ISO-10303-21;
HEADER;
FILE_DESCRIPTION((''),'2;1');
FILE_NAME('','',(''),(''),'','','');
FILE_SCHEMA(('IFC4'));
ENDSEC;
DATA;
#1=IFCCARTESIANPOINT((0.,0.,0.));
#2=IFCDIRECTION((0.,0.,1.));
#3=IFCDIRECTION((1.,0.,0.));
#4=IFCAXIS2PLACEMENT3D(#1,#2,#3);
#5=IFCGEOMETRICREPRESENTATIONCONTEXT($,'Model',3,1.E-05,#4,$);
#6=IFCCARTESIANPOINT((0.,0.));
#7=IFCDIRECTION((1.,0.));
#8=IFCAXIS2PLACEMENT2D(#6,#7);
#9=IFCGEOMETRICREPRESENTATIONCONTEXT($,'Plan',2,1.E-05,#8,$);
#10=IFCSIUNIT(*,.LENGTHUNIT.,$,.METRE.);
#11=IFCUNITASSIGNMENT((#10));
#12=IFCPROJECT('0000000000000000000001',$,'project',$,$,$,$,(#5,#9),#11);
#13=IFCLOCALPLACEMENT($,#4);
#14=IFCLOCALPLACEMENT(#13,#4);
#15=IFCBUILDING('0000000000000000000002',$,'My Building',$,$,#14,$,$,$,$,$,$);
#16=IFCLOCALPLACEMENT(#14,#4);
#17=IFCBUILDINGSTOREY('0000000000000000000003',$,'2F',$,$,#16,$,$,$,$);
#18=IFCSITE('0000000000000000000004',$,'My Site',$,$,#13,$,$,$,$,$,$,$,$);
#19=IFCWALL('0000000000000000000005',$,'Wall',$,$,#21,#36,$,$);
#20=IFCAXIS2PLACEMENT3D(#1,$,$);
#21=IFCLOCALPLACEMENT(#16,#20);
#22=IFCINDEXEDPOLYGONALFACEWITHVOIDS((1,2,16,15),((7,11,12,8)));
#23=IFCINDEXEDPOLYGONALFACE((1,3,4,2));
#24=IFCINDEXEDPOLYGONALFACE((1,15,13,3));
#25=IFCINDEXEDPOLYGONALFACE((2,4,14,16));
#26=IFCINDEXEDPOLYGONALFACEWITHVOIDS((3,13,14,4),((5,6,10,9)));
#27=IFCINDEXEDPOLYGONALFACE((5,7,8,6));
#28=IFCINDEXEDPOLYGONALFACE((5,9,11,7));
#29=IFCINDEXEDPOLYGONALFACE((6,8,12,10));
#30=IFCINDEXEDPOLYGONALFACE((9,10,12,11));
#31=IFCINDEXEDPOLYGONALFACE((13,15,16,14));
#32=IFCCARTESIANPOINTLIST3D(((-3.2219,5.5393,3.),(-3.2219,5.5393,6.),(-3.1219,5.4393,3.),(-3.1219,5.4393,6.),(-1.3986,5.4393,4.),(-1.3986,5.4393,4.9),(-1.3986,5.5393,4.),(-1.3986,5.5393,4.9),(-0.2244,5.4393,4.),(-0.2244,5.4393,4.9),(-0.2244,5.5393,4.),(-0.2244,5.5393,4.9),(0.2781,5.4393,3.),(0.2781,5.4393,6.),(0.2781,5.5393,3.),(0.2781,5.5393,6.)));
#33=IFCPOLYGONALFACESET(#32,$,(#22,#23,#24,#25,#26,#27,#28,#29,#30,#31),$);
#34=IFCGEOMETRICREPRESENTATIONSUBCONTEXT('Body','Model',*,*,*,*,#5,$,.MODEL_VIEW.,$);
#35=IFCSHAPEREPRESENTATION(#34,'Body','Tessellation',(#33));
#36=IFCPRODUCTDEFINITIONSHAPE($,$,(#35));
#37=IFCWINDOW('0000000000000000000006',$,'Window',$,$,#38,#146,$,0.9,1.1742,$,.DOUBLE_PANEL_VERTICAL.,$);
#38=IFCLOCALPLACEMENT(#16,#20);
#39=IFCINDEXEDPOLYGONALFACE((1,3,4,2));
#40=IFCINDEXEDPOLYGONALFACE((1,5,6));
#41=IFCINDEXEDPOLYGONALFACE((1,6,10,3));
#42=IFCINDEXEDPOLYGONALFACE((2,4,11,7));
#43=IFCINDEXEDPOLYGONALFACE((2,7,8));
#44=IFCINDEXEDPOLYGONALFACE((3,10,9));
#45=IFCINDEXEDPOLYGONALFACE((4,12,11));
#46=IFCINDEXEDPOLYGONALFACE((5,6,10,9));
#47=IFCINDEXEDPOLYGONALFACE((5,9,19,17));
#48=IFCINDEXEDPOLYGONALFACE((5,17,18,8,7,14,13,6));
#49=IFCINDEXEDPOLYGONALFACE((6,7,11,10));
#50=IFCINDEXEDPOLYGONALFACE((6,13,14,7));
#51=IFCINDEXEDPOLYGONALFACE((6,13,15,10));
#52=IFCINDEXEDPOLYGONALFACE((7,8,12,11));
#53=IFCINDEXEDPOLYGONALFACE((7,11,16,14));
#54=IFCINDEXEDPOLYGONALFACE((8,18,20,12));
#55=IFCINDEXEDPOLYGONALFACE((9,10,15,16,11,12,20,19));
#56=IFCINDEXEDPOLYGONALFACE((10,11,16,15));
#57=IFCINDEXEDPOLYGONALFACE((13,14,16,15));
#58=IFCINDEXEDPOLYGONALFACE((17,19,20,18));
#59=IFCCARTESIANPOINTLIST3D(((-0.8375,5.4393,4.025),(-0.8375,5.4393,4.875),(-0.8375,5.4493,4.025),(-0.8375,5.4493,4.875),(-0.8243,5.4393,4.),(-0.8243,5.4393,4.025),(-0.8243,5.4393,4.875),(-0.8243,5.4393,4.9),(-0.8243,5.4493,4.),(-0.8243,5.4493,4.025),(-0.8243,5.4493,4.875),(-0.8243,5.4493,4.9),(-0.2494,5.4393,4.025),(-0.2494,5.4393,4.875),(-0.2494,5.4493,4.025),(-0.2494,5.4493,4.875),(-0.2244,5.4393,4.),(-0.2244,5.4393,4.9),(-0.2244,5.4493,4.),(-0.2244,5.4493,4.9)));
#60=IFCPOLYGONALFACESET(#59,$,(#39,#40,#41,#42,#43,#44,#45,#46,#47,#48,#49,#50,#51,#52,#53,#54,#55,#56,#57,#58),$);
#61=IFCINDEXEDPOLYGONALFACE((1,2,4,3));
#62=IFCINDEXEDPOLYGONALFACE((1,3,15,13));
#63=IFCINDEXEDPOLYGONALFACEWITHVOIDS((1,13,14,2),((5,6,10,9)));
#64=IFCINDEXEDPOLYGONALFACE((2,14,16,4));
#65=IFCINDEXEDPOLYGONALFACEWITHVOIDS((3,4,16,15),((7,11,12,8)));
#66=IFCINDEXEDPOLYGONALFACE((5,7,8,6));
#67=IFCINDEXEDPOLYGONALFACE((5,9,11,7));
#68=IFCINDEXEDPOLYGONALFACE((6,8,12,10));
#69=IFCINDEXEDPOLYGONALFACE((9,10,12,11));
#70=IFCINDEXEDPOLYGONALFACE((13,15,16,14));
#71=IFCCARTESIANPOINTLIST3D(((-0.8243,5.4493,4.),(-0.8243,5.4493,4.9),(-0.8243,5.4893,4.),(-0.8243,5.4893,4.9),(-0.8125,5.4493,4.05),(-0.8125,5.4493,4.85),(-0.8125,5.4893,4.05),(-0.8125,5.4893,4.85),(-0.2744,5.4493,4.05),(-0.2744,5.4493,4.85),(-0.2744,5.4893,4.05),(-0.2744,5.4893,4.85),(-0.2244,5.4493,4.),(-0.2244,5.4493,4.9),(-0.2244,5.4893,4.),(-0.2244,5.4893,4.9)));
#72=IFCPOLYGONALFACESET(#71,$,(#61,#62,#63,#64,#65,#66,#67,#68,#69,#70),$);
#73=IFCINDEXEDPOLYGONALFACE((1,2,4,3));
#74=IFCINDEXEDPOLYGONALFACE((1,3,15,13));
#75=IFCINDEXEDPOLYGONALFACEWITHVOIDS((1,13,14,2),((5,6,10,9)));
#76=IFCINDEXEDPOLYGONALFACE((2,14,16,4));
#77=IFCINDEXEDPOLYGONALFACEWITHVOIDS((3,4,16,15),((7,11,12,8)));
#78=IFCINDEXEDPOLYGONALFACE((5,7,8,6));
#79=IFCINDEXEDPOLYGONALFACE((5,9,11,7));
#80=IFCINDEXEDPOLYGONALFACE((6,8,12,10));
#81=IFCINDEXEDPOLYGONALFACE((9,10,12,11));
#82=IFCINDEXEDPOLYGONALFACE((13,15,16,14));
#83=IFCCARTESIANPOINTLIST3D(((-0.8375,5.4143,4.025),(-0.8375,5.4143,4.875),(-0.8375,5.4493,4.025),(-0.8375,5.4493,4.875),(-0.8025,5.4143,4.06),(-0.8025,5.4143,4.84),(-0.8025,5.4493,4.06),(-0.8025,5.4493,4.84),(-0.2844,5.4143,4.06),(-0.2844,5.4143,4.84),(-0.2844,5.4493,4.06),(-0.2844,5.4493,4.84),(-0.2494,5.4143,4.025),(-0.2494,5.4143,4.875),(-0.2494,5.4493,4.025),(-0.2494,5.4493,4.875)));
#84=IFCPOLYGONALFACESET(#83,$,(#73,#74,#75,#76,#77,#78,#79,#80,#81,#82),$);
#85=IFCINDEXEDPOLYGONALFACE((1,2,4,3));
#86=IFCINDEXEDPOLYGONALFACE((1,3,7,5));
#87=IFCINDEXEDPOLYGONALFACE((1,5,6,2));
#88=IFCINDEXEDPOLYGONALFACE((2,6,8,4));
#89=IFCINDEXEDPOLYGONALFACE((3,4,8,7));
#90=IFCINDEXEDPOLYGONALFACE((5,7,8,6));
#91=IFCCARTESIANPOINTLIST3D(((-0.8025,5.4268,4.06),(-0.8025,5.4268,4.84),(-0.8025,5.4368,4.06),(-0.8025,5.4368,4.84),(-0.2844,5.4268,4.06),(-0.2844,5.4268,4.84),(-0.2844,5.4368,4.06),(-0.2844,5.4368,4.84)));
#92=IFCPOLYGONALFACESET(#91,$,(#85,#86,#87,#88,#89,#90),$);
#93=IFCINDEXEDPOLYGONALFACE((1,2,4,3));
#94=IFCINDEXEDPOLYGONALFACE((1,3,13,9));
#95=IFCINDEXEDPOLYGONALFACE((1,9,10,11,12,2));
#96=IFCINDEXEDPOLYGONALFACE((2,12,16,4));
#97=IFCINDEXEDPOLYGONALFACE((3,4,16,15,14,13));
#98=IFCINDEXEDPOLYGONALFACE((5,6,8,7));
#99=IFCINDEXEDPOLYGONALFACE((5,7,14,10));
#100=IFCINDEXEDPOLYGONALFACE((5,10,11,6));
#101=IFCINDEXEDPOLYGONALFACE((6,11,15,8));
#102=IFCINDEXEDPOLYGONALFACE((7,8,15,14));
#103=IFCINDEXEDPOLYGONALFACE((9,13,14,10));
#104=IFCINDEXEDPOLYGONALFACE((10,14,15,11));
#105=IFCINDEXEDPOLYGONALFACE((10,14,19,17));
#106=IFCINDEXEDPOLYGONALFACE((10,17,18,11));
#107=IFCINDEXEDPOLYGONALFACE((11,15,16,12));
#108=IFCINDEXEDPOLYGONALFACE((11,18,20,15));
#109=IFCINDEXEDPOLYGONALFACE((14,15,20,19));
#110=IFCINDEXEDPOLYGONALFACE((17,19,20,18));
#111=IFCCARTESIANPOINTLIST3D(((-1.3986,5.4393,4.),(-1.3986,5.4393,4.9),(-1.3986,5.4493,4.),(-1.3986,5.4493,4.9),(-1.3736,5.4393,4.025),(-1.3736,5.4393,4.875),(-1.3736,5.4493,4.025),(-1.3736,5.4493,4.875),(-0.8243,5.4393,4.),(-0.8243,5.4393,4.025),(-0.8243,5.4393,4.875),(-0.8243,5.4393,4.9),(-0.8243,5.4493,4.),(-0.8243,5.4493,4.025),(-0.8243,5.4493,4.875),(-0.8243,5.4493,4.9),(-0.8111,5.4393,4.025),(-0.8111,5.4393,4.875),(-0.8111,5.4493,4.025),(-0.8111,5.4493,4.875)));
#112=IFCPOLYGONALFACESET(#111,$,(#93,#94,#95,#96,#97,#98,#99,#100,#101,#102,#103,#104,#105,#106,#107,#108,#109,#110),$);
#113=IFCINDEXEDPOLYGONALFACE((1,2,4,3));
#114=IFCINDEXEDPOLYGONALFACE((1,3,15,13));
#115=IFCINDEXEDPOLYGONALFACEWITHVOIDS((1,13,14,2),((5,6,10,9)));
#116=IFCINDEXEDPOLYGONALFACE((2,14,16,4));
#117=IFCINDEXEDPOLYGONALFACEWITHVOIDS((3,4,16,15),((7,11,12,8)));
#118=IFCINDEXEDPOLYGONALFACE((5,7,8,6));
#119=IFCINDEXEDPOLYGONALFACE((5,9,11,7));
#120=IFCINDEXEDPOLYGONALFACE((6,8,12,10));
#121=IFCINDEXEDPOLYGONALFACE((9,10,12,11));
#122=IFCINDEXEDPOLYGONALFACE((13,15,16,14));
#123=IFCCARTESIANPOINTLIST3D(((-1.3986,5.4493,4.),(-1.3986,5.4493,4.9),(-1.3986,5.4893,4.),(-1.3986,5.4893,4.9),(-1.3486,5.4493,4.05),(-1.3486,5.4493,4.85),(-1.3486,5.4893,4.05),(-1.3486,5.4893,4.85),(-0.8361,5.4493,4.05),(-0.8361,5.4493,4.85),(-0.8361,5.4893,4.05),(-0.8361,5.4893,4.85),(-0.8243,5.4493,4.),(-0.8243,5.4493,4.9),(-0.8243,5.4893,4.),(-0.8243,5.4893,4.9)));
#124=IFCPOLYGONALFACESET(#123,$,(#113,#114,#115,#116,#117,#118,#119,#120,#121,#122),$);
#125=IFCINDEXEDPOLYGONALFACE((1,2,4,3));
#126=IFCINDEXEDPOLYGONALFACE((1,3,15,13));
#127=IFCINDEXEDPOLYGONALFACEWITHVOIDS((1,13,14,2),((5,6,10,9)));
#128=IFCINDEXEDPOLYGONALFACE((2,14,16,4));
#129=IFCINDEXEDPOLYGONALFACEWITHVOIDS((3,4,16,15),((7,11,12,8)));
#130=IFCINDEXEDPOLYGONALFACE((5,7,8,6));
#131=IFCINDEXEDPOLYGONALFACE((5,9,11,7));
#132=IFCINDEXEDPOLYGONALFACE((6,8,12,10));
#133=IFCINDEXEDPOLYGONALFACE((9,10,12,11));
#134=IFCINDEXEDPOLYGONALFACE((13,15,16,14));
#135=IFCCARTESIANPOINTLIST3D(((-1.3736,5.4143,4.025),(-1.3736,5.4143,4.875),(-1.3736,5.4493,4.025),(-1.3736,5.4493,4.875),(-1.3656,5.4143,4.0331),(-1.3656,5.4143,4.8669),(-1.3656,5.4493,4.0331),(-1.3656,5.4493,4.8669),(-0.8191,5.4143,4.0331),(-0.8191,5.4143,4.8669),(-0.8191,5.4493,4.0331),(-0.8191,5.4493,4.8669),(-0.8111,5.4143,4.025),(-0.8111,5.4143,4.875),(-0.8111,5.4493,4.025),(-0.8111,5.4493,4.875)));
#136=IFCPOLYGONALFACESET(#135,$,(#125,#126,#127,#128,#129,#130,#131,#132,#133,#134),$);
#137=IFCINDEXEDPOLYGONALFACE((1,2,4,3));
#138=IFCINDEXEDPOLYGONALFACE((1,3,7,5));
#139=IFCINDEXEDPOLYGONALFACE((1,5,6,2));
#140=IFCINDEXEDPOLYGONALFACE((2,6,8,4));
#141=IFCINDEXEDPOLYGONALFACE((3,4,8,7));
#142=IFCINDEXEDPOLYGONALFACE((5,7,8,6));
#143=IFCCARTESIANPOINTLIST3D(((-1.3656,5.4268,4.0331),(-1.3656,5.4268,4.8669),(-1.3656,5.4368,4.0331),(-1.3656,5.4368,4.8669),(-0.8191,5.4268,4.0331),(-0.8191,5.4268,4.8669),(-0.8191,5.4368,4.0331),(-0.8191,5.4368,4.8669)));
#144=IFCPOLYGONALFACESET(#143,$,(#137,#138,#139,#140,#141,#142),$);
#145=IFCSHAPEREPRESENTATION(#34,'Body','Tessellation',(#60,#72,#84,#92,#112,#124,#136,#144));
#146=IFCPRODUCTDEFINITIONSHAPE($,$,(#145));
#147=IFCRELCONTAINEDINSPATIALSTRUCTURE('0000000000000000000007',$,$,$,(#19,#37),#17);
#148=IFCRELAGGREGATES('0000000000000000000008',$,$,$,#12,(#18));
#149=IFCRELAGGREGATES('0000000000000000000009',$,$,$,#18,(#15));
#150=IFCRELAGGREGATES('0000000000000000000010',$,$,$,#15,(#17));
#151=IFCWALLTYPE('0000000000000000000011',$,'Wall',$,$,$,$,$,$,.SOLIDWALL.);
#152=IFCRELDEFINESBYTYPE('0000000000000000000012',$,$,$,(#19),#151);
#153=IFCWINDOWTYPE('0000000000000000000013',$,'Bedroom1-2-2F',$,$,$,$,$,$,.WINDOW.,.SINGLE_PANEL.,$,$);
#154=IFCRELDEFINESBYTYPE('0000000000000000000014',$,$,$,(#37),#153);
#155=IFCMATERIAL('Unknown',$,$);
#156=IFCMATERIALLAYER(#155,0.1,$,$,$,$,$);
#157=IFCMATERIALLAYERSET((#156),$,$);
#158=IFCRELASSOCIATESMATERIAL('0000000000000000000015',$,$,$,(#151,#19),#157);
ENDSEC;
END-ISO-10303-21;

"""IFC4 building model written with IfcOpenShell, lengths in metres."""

from ifc_helpers import new_model, entity, si_unit, frame, origin_with_axes, origin_2d_with_axis, place, context, subcontext, project, spatial, line, indexed_curve, outline, extrude, shape, source, transform, mapped, material, layer, layer_set, layer_usage, type_object, type_shapes, element, fill, save


model = new_model("IFC4")

# Units and contexts
model_context = context("Model", 3, precision=1e-05, world=origin_with_axes())
plan_context = context("Plan", 2, precision=1e-05, world=origin_2d_with_axis())
body_context_1 = subcontext(model_context, "Body", "Model", "MODEL_VIEW")
body_context_2 = subcontext(plan_context, "Body", "Plan", "PLAN_VIEW")
ifc_project = project(units=[si_unit("LENGTHUNIT", "METRE")], contexts=[model_context, plan_context])

# Site, building, storey
site_placement = place(None, origin_with_axes())
site = spatial("IfcSite", under=ifc_project, at=site_placement, Name="My Site")
building_placement = place(site_placement, origin_with_axes())
building = spatial("IfcBuilding", under=site, at=building_placement, Name="My Building")
storey_placement = place(building_placement, origin_with_axes())
storey = spatial("IfcBuildingStorey", under=building, at=storey_placement, Name="2F")

# Shared definitions
ifc_material = material(Name="Unknown")

# Shared definitions
ifc_layer = layer(ifc_material, 0.1)
ifc_layer_set = layer_set([ifc_layer])
wall_type = type_object("IfcWallType", Name="Wall", PredefinedType="SOLIDWALL", material=ifc_layer_set)

# Wall, opening, window
ifc_layer_usage_1 = layer_usage(ifc_layer_set, "AXIS2", "POSITIVE", 0.0)
wall_1_placement = place(storey_placement, frame((0.2781, 5.5393, 3.0), z_axis=(0.0, 0.0, 1.0), x_axis=(-1.0, 0.0, 0.0)))
wall_1 = element("IfcWall", 1, at=wall_1_placement, inside=storey, type_object=wall_type, material=ifc_layer_usage_1, Name="Wall", context=body_context_1, shape_type="SweptSolid", body=[
    extrude(outline(indexed_curve([(0.0, 0.0), (0.0, 0.1), (3.4, 0.1), (3.5, 0.0)], segments=[line(1, 2, 3, 4, 1)])), origin_with_axes(), (0.0, 0.0, 1.0), 3.0),
])
shared_shape_1 = source(origin_with_axes(), body_context_1, "Body", "SweptSolid", [
    extrude(outline(indexed_curve([(0.0, 0.0), (1.1742, 0.0), (1.1742, 0.9), (0.0, 0.9)], segments=[line(1, 2, 3, 4, 1)])), frame((0.0, -0.6, 0.0), z_axis=(0.0, -1.0, 0.0), x_axis=(1.0, 0.0, 0.0)), (0.0, 0.0, -1.0), 1.2),
])
opening_1_placement = place(wall_1_placement, frame((0.5025, 0.0, 1.0), z_axis=(0.0, 0.0, 1.0), x_axis=(1.0, 0.0, 0.0)))
opening_1 = element("IfcOpeningElement", 2, at=opening_1_placement, cuts=wall_1, PredefinedType="OPENING", context=body_context_1, shape_type="MappedRepresentation", body=[
    mapped(shared_shape_1, transform((0.0, 0.0, 0.0), x_axis=(1.0, 0.0, 0.0), y_axis=(0.0, 1.0, 0.0), z_axis=(0.0, 0.0, 1.0), scale=1.0)),
])
window_type_1 = type_object("IfcWindowType", Name="Bedroom1-2-2F", PartitioningType="SINGLE_PANEL", PredefinedType="WINDOW")
shared_shape_2 = source(origin_with_axes(), body_context_1, "Body", "SweptSolid", [
    extrude(outline(indexed_curve([(0.0, 0.0), (0.5999, 0.0), (0.5999, 0.9), (0.0, 0.9)], segments=[line(1, 2, 3, 4, 1)]), holes=[indexed_curve([(0.025, 0.025), (0.6131, 0.025), (0.6131, 0.875), (0.025, 0.875)], segments=[line(1, 2, 3, 4, 1)])]), frame((0.0, 0.09, 0.0), z_axis=(0.0, -1.0, 0.0), x_axis=(1.0, 0.0, 0.0)), (0.0, 0.0, -1.0), 0.01),
    extrude(outline(indexed_curve([(0.0, 0.0), (0.5999, 0.0), (0.5999, 0.9), (0.0, 0.9)], segments=[line(1, 2, 3, 4, 1)]), holes=[indexed_curve([(0.05, 0.05), (0.5881, 0.05), (0.5881, 0.85), (0.05, 0.85)], segments=[line(1, 2, 3, 4, 1)])]), frame((0.0, 0.05, 0.0), z_axis=(0.0, -1.0, 0.0), x_axis=(1.0, 0.0, 0.0)), (0.0, 0.0, -1.0), 0.04),
    extrude(outline(indexed_curve([(0.0, 0.0), (0.5881, 0.0), (0.5881, 0.85), (0.0, 0.85)], segments=[line(1, 2, 3, 4, 1)]), holes=[indexed_curve([(0.035, 0.035), (0.5531, 0.035), (0.5531, 0.815), (0.035, 0.815)], segments=[line(1, 2, 3, 4, 1)])]), frame((0.025, 0.09, 0.025), z_axis=(0.0, -1.0, 0.0), x_axis=(1.0, 0.0, 0.0)), (0.0, 0.0, -1.0), 0.035),
    extrude(outline(indexed_curve([(0.035, 0.035), (0.5531, 0.035), (0.5531, 0.815), (0.035, 0.815)], segments=[line(1, 2, 3, 4, 1)])), frame((0.025, 0.1025, 0.025), z_axis=(0.0, -1.0, 0.0), x_axis=(1.0, 0.0, 0.0)), (0.0, 0.0, -1.0), 0.01),
    extrude(outline(indexed_curve([(0.0, 0.0), (0.5744, 0.0), (0.5744, 0.9), (0.0, 0.9)], segments=[line(1, 2, 3, 4, 1)]), holes=[indexed_curve([(-0.0132, 0.025), (0.5494, 0.025), (0.5494, 0.875), (-0.0132, 0.875)], segments=[line(1, 2, 3, 4, 1)])]), frame((0.5999, 0.09, 0.0), z_axis=(0.0, -1.0, 0.0), x_axis=(1.0, 0.0, 0.0)), (0.0, 0.0, -1.0), 0.01),
    extrude(outline(indexed_curve([(0.0, 0.0), (0.5744, 0.0), (0.5744, 0.9), (0.0, 0.9)], segments=[line(1, 2, 3, 4, 1)]), holes=[indexed_curve([(0.0118, 0.05), (0.5244, 0.05), (0.5244, 0.85), (0.0118, 0.85)], segments=[line(1, 2, 3, 4, 1)])]), frame((0.5999, 0.05, 0.0), z_axis=(0.0, -1.0, 0.0), x_axis=(1.0, 0.0, 0.0)), (0.0, 0.0, -1.0), 0.04),
    extrude(outline(indexed_curve([(0.0, 0.0), (0.5626, 0.0), (0.5626, 0.85), (0.0, 0.85)], segments=[line(1, 2, 3, 4, 1)]), holes=[indexed_curve([(0.0081, 0.0081), (0.5545, 0.0081), (0.5545, 0.8419), (0.0081, 0.8419)], segments=[line(1, 2, 3, 4, 1)])]), frame((0.5866, 0.09, 0.025), z_axis=(0.0, -1.0, 0.0), x_axis=(1.0, 0.0, 0.0)), (0.0, 0.0, -1.0), 0.035),
    extrude(outline(indexed_curve([(0.0081, 0.0081), (0.5545, 0.0081), (0.5545, 0.8419), (0.0081, 0.8419)], segments=[line(1, 2, 3, 4, 1)])), frame((0.5866, 0.1025, 0.025), z_axis=(0.0, -1.0, 0.0), x_axis=(1.0, 0.0, 0.0)), (0.0, 0.0, -1.0), 0.01),
])
shared_shape_3 = source(origin_with_axes(), body_context_2, "Body", "Curve2D", [
    entity("IfcIndexedPolyCurve", entity("IfcCartesianPointList2D", [[0.05, 0.05], [0.5881, 0.05]])),
    entity("IfcIndexedPolyCurve", entity("IfcCartesianPointList2D", [[0.0, 0.1], [0.025, 0.1], [0.025, 0.09], [0.05, 0.09], [0.05, 0.05], [0.0, 0.05]]), [entity("IfcLineIndex", [1, 2, 3, 4, 5, 6, 1])]),
    entity("IfcIndexedPolyCurve", entity("IfcCartesianPointList2D", [[0.5999, 0.1], [0.6131, 0.1], [0.6131, 0.09], [0.5881, 0.09], [0.5881, 0.05], [0.5999, 0.05]])),
    entity("IfcIndexedPolyCurve", entity("IfcCartesianPointList2D", [[0.025, 0.09], [0.06, 0.09], [0.06, 0.125], [0.025, 0.125]]), [entity("IfcLineIndex", [1, 2, 3, 4, 1])]),
    entity("IfcIndexedPolyCurve", entity("IfcCartesianPointList2D", [[0.6131, 0.09], [0.5781, 0.09], [0.5781, 0.125], [0.6131, 0.125]]), [entity("IfcLineIndex", [1, 2, 3, 4, 1])]),
    entity("IfcIndexedPolyCurve", entity("IfcCartesianPointList2D", [[0.06, 0.09], [0.5781, 0.09]])),
    entity("IfcIndexedPolyCurve", entity("IfcCartesianPointList2D", [[0.06, 0.125], [0.5781, 0.125]])),
    entity("IfcIndexedPolyCurve", entity("IfcCartesianPointList2D", [[0.06, 0.1075], [0.5781, 0.1075]])),
    entity("IfcIndexedPolyCurve", entity("IfcCartesianPointList2D", [[0.6116, 0.05], [1.1242, 0.05]])),
    entity("IfcIndexedPolyCurve", entity("IfcCartesianPointList2D", [[0.5999, 0.1], [0.5866, 0.1], [0.5866, 0.09], [0.6116, 0.09], [0.6116, 0.05], [0.5999, 0.05]])),
    entity("IfcIndexedPolyCurve", entity("IfcCartesianPointList2D", [[1.1742, 0.1], [1.1492, 0.1], [1.1492, 0.09], [1.1242, 0.09], [1.1242, 0.05], [1.1742, 0.05]]), [entity("IfcLineIndex", [1, 2, 3, 4, 5, 6, 1])]),
    entity("IfcIndexedPolyCurve", entity("IfcCartesianPointList2D", [[0.5866, 0.09], [0.5947, 0.09], [0.5947, 0.125], [0.5866, 0.125]]), [entity("IfcLineIndex", [1, 2, 3, 4, 1])]),
    entity("IfcIndexedPolyCurve", entity("IfcCartesianPointList2D", [[1.1492, 0.09], [1.1412, 0.09], [1.1412, 0.125], [1.1492, 0.125]]), [entity("IfcLineIndex", [1, 2, 3, 4, 1])]),
    entity("IfcIndexedPolyCurve", entity("IfcCartesianPointList2D", [[0.5947, 0.09], [1.1412, 0.09]])),
    entity("IfcIndexedPolyCurve", entity("IfcCartesianPointList2D", [[0.5947, 0.125], [1.1412, 0.125]])),
    entity("IfcIndexedPolyCurve", entity("IfcCartesianPointList2D", [[0.5947, 0.1075], [1.1412, 0.1075]])),
])
type_shapes(window_type_1, [shared_shape_2, shared_shape_3])
window_1_placement = place(opening_1_placement, frame((0.0, 0.0, 0.0), z_axis=(0.0, 0.0, 1.0), x_axis=(1.0, 0.0, 0.0)))
window_1 = element("IfcWindow", 3, at=window_1_placement, inside=storey, type_object=window_type_1, Name="Window", OverallHeight=0.9, OverallWidth=1.1742, PartitioningType="DOUBLE_PANEL_VERTICAL", shapes=[
    shape(body_context_1, "Body", "MappedRepresentation", [mapped(shared_shape_2, transform((0.0, 0.0, 0.0), x_axis=(1.0, 0.0, 0.0), y_axis=(0.0, 1.0, 0.0), z_axis=(0.0, 0.0, 1.0), scale=1.0))]),
    shape(body_context_2, "Body", "MappedRepresentation", [mapped(shared_shape_3, transform((0.0, 0.0, 0.0), x_axis=(1.0, 0.0, 0.0), y_axis=(0.0, 1.0, 0.0), z_axis=(0.0, 0.0, 1.0), scale=1.0))]),
])
fill(opening_1, window_1)

save(model, "model.ifc")
